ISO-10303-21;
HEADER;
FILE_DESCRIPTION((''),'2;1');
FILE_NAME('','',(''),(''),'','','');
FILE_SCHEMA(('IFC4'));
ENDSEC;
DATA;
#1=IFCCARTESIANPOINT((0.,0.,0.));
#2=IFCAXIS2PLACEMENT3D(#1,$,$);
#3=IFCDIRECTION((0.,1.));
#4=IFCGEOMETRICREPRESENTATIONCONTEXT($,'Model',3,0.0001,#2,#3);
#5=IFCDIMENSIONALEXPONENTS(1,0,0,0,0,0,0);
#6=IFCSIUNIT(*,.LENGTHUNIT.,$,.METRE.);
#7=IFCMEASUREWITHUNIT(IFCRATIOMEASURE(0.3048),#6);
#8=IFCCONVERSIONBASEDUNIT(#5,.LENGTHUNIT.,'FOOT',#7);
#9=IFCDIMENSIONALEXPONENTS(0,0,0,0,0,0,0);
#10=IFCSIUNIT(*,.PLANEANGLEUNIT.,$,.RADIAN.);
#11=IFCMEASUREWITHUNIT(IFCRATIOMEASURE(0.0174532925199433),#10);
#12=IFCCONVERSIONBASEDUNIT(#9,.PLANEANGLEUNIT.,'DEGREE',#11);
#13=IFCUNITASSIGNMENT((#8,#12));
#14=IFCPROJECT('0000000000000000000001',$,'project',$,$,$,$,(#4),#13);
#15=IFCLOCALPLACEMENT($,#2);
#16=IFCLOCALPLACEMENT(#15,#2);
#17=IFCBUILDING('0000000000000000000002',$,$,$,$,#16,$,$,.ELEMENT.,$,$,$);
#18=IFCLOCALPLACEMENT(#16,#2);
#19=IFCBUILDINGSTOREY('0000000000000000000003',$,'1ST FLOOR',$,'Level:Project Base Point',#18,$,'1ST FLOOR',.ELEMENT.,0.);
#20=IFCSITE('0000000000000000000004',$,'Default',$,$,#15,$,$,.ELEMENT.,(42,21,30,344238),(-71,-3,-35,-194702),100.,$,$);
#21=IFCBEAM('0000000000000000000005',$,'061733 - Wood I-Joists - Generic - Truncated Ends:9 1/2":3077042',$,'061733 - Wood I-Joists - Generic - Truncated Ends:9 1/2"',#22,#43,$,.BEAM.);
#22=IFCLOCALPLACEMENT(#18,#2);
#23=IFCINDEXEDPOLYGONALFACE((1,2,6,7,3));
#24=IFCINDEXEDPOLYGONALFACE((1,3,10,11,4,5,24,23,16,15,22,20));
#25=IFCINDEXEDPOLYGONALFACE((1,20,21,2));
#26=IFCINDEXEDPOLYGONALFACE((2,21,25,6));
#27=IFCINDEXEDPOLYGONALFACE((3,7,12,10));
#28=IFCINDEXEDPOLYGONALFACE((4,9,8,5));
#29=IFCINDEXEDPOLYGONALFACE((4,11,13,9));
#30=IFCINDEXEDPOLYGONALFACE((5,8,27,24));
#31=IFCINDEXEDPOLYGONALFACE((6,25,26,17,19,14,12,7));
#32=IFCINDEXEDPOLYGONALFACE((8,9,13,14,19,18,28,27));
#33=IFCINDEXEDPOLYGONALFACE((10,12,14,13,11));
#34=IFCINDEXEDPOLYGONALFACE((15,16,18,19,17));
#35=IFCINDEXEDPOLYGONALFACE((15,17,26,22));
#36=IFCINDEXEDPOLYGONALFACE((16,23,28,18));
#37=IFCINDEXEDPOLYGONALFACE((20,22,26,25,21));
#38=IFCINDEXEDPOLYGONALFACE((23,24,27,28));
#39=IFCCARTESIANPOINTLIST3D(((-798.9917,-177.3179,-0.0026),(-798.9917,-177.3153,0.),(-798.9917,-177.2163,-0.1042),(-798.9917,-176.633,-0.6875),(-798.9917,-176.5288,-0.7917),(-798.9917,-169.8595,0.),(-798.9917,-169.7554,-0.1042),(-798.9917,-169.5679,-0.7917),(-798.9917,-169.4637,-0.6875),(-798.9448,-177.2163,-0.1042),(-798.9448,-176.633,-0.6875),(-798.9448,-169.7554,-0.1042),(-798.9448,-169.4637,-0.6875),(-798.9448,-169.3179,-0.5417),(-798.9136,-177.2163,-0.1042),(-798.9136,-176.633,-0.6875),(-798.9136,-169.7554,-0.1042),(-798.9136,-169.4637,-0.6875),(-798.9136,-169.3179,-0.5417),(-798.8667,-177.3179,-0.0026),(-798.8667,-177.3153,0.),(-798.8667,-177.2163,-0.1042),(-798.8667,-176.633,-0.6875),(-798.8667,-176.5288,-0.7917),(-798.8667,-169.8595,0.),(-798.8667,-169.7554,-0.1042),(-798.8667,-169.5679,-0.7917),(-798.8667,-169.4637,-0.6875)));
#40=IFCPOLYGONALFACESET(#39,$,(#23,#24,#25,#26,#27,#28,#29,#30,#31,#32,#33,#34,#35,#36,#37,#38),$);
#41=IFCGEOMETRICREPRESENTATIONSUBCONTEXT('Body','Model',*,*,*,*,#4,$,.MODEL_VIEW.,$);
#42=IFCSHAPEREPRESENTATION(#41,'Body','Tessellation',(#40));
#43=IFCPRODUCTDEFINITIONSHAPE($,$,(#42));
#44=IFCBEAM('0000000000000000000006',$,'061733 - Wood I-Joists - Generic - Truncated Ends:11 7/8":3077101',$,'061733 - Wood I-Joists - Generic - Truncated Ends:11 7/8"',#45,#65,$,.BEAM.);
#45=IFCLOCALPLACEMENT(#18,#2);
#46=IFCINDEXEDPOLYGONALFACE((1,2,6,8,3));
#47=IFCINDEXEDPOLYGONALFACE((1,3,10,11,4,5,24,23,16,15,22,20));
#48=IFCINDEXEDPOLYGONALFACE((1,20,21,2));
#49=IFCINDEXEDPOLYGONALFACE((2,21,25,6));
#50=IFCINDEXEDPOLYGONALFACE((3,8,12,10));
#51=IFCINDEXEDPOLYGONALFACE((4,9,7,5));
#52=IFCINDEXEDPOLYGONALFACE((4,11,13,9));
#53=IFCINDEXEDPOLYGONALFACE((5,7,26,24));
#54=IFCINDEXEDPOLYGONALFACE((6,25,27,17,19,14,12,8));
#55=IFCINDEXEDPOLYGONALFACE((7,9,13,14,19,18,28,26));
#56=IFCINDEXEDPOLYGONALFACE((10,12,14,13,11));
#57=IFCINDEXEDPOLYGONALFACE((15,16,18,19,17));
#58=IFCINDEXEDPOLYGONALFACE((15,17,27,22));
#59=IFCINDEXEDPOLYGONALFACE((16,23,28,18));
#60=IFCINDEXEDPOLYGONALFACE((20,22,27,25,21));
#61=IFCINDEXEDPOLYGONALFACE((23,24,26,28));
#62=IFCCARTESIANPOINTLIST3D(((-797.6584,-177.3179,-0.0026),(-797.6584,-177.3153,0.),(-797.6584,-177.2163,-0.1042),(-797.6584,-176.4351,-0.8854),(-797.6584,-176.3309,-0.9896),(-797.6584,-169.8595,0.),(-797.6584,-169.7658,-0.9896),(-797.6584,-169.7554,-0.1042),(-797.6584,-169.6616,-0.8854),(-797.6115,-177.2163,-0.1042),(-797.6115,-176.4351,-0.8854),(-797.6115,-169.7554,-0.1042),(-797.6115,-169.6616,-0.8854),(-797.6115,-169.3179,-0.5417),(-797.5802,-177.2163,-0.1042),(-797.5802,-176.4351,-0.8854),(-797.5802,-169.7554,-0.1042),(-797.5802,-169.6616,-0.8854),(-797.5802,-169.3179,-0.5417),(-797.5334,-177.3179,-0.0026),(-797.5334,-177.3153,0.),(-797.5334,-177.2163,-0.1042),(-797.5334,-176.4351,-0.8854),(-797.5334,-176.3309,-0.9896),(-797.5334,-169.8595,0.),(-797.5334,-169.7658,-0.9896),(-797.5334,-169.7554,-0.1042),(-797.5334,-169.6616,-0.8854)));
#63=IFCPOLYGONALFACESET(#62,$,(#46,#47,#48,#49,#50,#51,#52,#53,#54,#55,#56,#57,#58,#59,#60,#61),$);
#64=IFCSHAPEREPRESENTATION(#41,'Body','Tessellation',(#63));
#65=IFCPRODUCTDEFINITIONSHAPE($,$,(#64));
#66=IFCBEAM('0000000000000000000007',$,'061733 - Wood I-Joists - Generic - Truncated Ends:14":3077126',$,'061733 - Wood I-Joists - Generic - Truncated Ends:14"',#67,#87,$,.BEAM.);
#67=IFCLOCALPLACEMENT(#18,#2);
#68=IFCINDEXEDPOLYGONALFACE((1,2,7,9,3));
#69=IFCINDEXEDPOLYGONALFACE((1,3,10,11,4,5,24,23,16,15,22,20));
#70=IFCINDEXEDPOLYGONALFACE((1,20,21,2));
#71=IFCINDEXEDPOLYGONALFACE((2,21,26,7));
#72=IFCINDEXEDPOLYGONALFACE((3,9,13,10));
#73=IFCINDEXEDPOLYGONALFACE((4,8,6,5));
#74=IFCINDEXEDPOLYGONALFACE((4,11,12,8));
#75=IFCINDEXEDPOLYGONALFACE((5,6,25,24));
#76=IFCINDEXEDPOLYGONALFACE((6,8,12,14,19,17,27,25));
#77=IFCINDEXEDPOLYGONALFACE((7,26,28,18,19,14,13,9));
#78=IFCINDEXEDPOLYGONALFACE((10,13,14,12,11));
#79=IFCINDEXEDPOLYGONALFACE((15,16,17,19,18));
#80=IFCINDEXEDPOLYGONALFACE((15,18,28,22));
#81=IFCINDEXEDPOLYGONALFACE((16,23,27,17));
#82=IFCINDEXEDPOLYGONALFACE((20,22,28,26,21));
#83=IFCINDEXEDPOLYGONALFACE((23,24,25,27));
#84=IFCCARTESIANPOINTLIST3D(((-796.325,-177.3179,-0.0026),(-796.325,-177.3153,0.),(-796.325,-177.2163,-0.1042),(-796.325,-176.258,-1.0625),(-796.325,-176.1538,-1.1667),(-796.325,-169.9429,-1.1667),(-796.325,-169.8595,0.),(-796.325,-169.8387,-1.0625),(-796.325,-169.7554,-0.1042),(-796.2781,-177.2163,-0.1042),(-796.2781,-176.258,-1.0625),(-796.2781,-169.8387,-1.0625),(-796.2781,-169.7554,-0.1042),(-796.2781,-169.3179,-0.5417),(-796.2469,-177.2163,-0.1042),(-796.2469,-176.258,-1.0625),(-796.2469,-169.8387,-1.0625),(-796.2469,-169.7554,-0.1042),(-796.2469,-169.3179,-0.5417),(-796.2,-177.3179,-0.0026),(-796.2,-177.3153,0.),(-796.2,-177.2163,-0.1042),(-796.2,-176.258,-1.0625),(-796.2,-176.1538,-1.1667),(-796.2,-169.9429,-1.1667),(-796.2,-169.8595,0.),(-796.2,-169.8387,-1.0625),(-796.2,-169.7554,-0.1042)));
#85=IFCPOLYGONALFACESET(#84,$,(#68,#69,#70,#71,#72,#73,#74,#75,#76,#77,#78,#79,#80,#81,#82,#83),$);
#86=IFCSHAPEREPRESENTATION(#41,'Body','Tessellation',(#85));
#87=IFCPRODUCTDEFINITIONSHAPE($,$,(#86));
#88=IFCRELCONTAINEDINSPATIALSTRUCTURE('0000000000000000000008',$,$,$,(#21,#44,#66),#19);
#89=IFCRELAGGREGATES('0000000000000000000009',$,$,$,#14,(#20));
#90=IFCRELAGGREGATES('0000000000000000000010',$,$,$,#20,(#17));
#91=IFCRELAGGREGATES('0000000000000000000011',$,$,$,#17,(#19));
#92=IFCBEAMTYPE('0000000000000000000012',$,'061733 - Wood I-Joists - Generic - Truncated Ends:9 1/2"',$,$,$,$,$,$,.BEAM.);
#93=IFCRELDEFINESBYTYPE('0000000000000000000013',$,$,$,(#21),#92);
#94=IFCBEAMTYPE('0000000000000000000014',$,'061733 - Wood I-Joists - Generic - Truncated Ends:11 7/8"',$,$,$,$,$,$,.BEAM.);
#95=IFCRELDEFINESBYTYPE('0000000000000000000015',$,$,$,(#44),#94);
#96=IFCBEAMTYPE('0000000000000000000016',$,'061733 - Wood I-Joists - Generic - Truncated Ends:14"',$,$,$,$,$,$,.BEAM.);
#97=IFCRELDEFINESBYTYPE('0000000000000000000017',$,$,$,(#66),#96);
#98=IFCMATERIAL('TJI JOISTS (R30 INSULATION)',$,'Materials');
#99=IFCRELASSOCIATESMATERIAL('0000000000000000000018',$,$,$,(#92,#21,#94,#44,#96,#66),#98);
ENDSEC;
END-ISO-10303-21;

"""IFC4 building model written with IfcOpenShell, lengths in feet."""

from ifc_helpers import new_model, entity, si_unit, converted_unit, direction, frame, origin, place, context, subcontext, project, spatial, polyline, outline, extrude, clip, bounded_halfspace, source, transform, mapped, material, material_profile, profile_set, profile_usage, type_object, type_shapes, element, save


model = new_model("IFC4")

# Units and contexts
model_context = context("Model", 3, precision=0.0001, world=origin(), true_north=direction((0.0, 1.0)))
body_context = subcontext(model_context, "Body", "Model", "MODEL_VIEW")
ifc_project = project(units=[converted_unit("LENGTHUNIT", "FOOT", entity("IfcRatioMeasure", 0.3048), si_unit("LENGTHUNIT", "METRE"), dimensions=[1, 0, 0, 0, 0, 0, 0]), converted_unit("PLANEANGLEUNIT", "DEGREE", entity("IfcRatioMeasure", 0.0174532925199433), si_unit("PLANEANGLEUNIT", "RADIAN"), dimensions=[0, 0, 0, 0, 0, 0, 0])], contexts=[model_context])

# Site, building, storey
site_placement = place(None, origin())
site = spatial("IfcSite", under=ifc_project, at=site_placement, Name="Default", CompositionType="ELEMENT", RefLatitude=(42, 21, 30, 344238), RefLongitude=(-71, -3, -35, -194702), RefElevation=100.0)
building_placement = place(site_placement, origin())
building = spatial("IfcBuilding", under=site, at=building_placement, CompositionType="ELEMENT")
storey_placement = place(building_placement, origin())
storey = spatial("IfcBuildingStorey", under=building, at=storey_placement, Name="1ST FLOOR", ObjectType="Level:Project Base Point", LongName="1ST FLOOR", CompositionType="ELEMENT", Elevation=0.0)

# Beams
ifc_material_1 = material(Name="TJI JOISTS (R30 INSULATION)", Category="Materials")
ifc_material_profile_1 = material_profile(ifc_material_1, outline(polyline([(-0.0625, -0.2917), (-0.0625, -0.3958), (0.0625, -0.3958), (0.0625, -0.2917), (0.0156, -0.2917), (0.0156, 0.2917), (0.0625, 0.2917), (0.0625, 0.3958), (-0.0625, 0.3958), (-0.0625, 0.2917), (-0.0156, 0.2917), (-0.0156, -0.2917), (-0.0625, -0.2917)])), Name="9 1/2\"")
ifc_profile_set_1 = profile_set([ifc_material_profile_1], Name="9 1/2\"")
ifc_profile_usage_1 = profile_usage(ifc_profile_set_1, cardinal=8)
beam_type_1 = type_object("IfcBeamType", Name="061733 - Wood I-Joists - Generic - Truncated Ends:9 1/2\"", PredefinedType="BEAM", material=ifc_profile_set_1)
shared_shape_1 = source(origin(), body_context, "Body", "Clipping", [
    clip(clip(clip(clip(extrude(outline(polyline([(-0.0625, -0.2917), (-0.0625, -0.3958), (0.0625, -0.3958), (0.0625, -0.2917), (0.0156, -0.2917), (0.0156, 0.2917), (0.0625, 0.2917), (0.0625, 0.3958), (-0.0625, 0.3958), (-0.0625, 0.2917), (-0.0156, 0.2917), (-0.0156, -0.2917), (-0.0625, -0.2917)])), frame((-4.0, -0.0057, 0.0), z_axis=(-1.0, 0.0, 0.0), x_axis=(0.0, 1.0, 0.0)), (0.0, 0.0, -1.0), 8.0), bounded_halfspace(frame((-3.75, -0.0682, -0.3958), z_axis=(-0.707107, 0.0, -0.707107), x_axis=(0.0, 1.0, 0.0)), False, frame((-4.0, -0.0057, 0.0), z_axis=(-1.0, 0.0, 0.0), x_axis=(0.0, 1.0, 0.0)), polyline([(-0.0156, 0.1458), (0.0156, 0.1458), (0.0156, 0.2917), (0.0625, 0.2917), (0.0625, 0.3958), (-0.0625, 0.3958), (-0.0625, 0.2917), (-0.0156, 0.2917), (-0.0156, 0.1458)]))), bounded_halfspace(frame((-4.0, -0.0682, -0.1458), z_axis=(-0.707107, 0.0, 0.707107), x_axis=(0.0, 1.0, 0.0)), False, frame((-4.0, -0.0057, 0.0), z_axis=(-1.0, 0.0, 0.0), x_axis=(0.0, 1.0, 0.0)), polyline([(0.0156, 0.1458), (-0.0156, 0.1458), (-0.0156, -0.2917), (-0.0625, -0.2917), (-0.0625, -0.3958), (0.0625, -0.3958), (0.0625, -0.2917), (0.0156, -0.2917), (0.0156, 0.1458)]))), bounded_halfspace(frame((4.0, -0.0682, 0.3932), z_axis=(0.707107, 0.0, -0.707107), x_axis=(0.0, 1.0, 0.0)), False, frame((-4.0, -0.0057, 0.0), z_axis=(-1.0, 0.0, 0.0), x_axis=(0.0, 1.0, 0.0)), polyline([(0.0625, -0.3932), (-0.0625, -0.3932), (-0.0625, -0.2917), (-0.0156, -0.2917), (-0.0156, 0.2917), (-0.0625, 0.2917), (-0.0625, 0.3958), (0.0625, 0.3958), (0.0625, 0.2917), (0.0156, 0.2917), (0.0156, -0.2917), (0.0625, -0.2917), (0.0625, -0.3932)]))), bounded_halfspace(frame((3.9974, -0.0682, 0.3958), z_axis=(0.707107, 0.0, 0.707107), x_axis=(0.0, 1.0, 0.0)), False, frame((-4.0, -0.0057, 0.0), z_axis=(-1.0, 0.0, 0.0), x_axis=(0.0, 1.0, 0.0)), polyline([(-0.0625, -0.3932), (0.0625, -0.3932), (0.0625, -0.3958), (-0.0625, -0.3958), (-0.0625, -0.3932)]))),
])
type_shapes(beam_type_1, [shared_shape_1])
beam_1_placement = place(storey_placement, frame((-798.9235, -173.3179, -0.3958), z_axis=(0.0, 0.0, 1.0), x_axis=(0.0, -1.0, 0.0)))
element("IfcBeam", 1, at=beam_1_placement, inside=storey, type_object=beam_type_1, material=ifc_profile_usage_1, Name="061733 - Wood I-Joists - Generic - Truncated Ends:9 1/2\":3077042", ObjectType="061733 - Wood I-Joists - Generic - Truncated Ends:9 1/2\"", PredefinedType="BEAM", context=body_context, shape_type="MappedRepresentation", body=[
    mapped(shared_shape_1, transform((0.0, 0.0, 0.0), scale=1.0)),
])
ifc_material_profile_2 = material_profile(ifc_material_1, outline(polyline([(-0.0625, -0.3906), (-0.0625, -0.4948), (0.0625, -0.4948), (0.0625, -0.3906), (0.0156, -0.3906), (0.0156, 0.3906), (0.0625, 0.3906), (0.0625, 0.4948), (-0.0625, 0.4948), (-0.0625, 0.3906), (-0.0156, 0.3906), (-0.0156, -0.3906), (-0.0625, -0.3906)])), Name="11 7/8\"")
ifc_profile_set_2 = profile_set([ifc_material_profile_2], Name="11 7/8\"")
ifc_profile_usage_2 = profile_usage(ifc_profile_set_2, cardinal=8)
beam_type_2 = type_object("IfcBeamType", Name="061733 - Wood I-Joists - Generic - Truncated Ends:11 7/8\"", PredefinedType="BEAM", material=ifc_profile_set_2)
shared_shape_2 = source(origin(), body_context, "Body", "Clipping", [
    clip(clip(clip(clip(extrude(outline(polyline([(-0.0625, -0.3906), (-0.0625, -0.4948), (0.0625, -0.4948), (0.0625, -0.3906), (0.0156, -0.3906), (0.0156, 0.3906), (0.0625, 0.3906), (0.0625, 0.4948), (-0.0625, 0.4948), (-0.0625, 0.3906), (-0.0156, 0.3906), (-0.0156, -0.3906), (-0.0625, -0.3906)])), frame((-4.0, -0.0057, 0.0), z_axis=(-1.0, 0.0, 0.0), x_axis=(0.0, 1.0, 0.0)), (0.0, 0.0, -1.0), 8.0), bounded_halfspace(frame((-3.5521, -0.0682, -0.4948), z_axis=(-0.707107, 0.0, -0.707107), x_axis=(0.0, 1.0, 0.0)), False, frame((-4.0, -0.0057, 0.0), z_axis=(-1.0, 0.0, 0.0), x_axis=(0.0, 1.0, 0.0)), polyline([(-0.0156, 0.0469), (0.0156, 0.0469), (0.0156, 0.3906), (0.0625, 0.3906), (0.0625, 0.4948), (-0.0625, 0.4948), (-0.0625, 0.3906), (-0.0156, 0.3906), (-0.0156, 0.0469)]))), bounded_halfspace(frame((-4.0, -0.0682, -0.0469), z_axis=(-0.707107, 0.0, 0.707107), x_axis=(0.0, 1.0, 0.0)), False, frame((-4.0, -0.0057, 0.0), z_axis=(-1.0, 0.0, 0.0), x_axis=(0.0, 1.0, 0.0)), polyline([(0.0156, 0.0469), (-0.0156, 0.0469), (-0.0156, -0.3906), (-0.0625, -0.3906), (-0.0625, -0.4948), (0.0625, -0.4948), (0.0625, -0.3906), (0.0156, -0.3906), (0.0156, 0.0469)]))), bounded_halfspace(frame((4.0, -0.0682, 0.4922), z_axis=(0.707107, 0.0, -0.707107), x_axis=(0.0, 1.0, 0.0)), False, frame((-4.0, -0.0057, 0.0), z_axis=(-1.0, 0.0, 0.0), x_axis=(0.0, 1.0, 0.0)), polyline([(0.0625, -0.4922), (-0.0625, -0.4922), (-0.0625, -0.3906), (-0.0156, -0.3906), (-0.0156, 0.3906), (-0.0625, 0.3906), (-0.0625, 0.4948), (0.0625, 0.4948), (0.0625, 0.3906), (0.0156, 0.3906), (0.0156, -0.3906), (0.0625, -0.3906), (0.0625, -0.4922)]))), bounded_halfspace(frame((3.9974, -0.0682, 0.4948), z_axis=(0.707107, 0.0, 0.707107), x_axis=(0.0, 1.0, 0.0)), False, frame((-4.0, -0.0057, 0.0), z_axis=(-1.0, 0.0, 0.0), x_axis=(0.0, 1.0, 0.0)), polyline([(-0.0625, -0.4922), (0.0625, -0.4922), (0.0625, -0.4948), (-0.0625, -0.4948), (-0.0625, -0.4922)]))),
])
type_shapes(beam_type_2, [shared_shape_2])
beam_2_placement = place(storey_placement, frame((-797.5901, -173.3179, -0.4948), z_axis=(0.0, 0.0, 1.0), x_axis=(0.0, -1.0, 0.0)))
element("IfcBeam", 2, at=beam_2_placement, inside=storey, type_object=beam_type_2, material=ifc_profile_usage_2, Name="061733 - Wood I-Joists - Generic - Truncated Ends:11 7/8\":3077101", ObjectType="061733 - Wood I-Joists - Generic - Truncated Ends:11 7/8\"", PredefinedType="BEAM", context=body_context, shape_type="MappedRepresentation", body=[
    mapped(shared_shape_2, transform((0.0, 0.0, 0.0), scale=1.0)),
])
ifc_material_profile_3 = material_profile(ifc_material_1, outline(polyline([(-0.0625, -0.4792), (-0.0625, -0.5833), (0.0625, -0.5833), (0.0625, -0.4792), (0.0156, -0.4792), (0.0156, 0.4792), (0.0625, 0.4792), (0.0625, 0.5833), (-0.0625, 0.5833), (-0.0625, 0.4792), (-0.0156, 0.4792), (-0.0156, -0.4792), (-0.0625, -0.4792)])), Name="14\"")
ifc_profile_set_3 = profile_set([ifc_material_profile_3], Name="14\"")
ifc_profile_usage_3 = profile_usage(ifc_profile_set_3, cardinal=8)
beam_type_3 = type_object("IfcBeamType", Name="061733 - Wood I-Joists - Generic - Truncated Ends:14\"", PredefinedType="BEAM", material=ifc_profile_set_3)
shared_shape_3 = source(origin(), body_context, "Body", "Clipping", [
    clip(clip(clip(clip(extrude(outline(polyline([(-0.0625, -0.4792), (-0.0625, -0.5833), (0.0625, -0.5833), (0.0625, -0.4792), (0.0156, -0.4792), (0.0156, 0.4792), (0.0625, 0.4792), (0.0625, 0.5833), (-0.0625, 0.5833), (-0.0625, 0.4792), (-0.0156, 0.4792), (-0.0156, -0.4792), (-0.0625, -0.4792)])), frame((-4.0, -0.0057, 0.0), z_axis=(-1.0, 0.0, 0.0), x_axis=(0.0, 1.0, 0.0)), (0.0, 0.0, -1.0), 8.0), bounded_halfspace(frame((-3.375, -0.0682, -0.5833), z_axis=(-0.707107, 0.0, -0.707107), x_axis=(0.0, 1.0, 0.0)), False, frame((-4.0, -0.0057, 0.0), z_axis=(-1.0, 0.0, 0.0), x_axis=(0.0, 1.0, 0.0)), polyline([(-0.0156, -0.0417), (0.0156, -0.0417), (0.0156, 0.4792), (0.0625, 0.4792), (0.0625, 0.5833), (-0.0625, 0.5833), (-0.0625, 0.4792), (-0.0156, 0.4792), (-0.0156, -0.0417)]))), bounded_halfspace(frame((-4.0, -0.0682, 0.0417), z_axis=(-0.707107, 0.0, 0.707107), x_axis=(0.0, 1.0, 0.0)), False, frame((-4.0, -0.0057, 0.0), z_axis=(-1.0, 0.0, 0.0), x_axis=(0.0, 1.0, 0.0)), polyline([(0.0156, -0.0417), (-0.0156, -0.0417), (-0.0156, -0.4792), (-0.0625, -0.4792), (-0.0625, -0.5833), (0.0625, -0.5833), (0.0625, -0.4792), (0.0156, -0.4792), (0.0156, -0.0417)]))), bounded_halfspace(frame((4.0, -0.0682, 0.5807), z_axis=(0.707107, 0.0, -0.707107), x_axis=(0.0, 1.0, 0.0)), False, frame((-4.0, -0.0057, 0.0), z_axis=(-1.0, 0.0, 0.0), x_axis=(0.0, 1.0, 0.0)), polyline([(0.0625, -0.5807), (-0.0625, -0.5807), (-0.0625, -0.4792), (-0.0156, -0.4792), (-0.0156, 0.4792), (-0.0625, 0.4792), (-0.0625, 0.5833), (0.0625, 0.5833), (0.0625, 0.4792), (0.0156, 0.4792), (0.0156, -0.4792), (0.0625, -0.4792), (0.0625, -0.5807)]))), bounded_halfspace(frame((3.9974, -0.0682, 0.5833), z_axis=(0.707107, 0.0, 0.707107), x_axis=(0.0, 1.0, 0.0)), False, frame((-4.0, -0.0057, 0.0), z_axis=(-1.0, 0.0, 0.0), x_axis=(0.0, 1.0, 0.0)), polyline([(-0.0625, -0.5807), (0.0625, -0.5807), (0.0625, -0.5833), (-0.0625, -0.5833), (-0.0625, -0.5807)]))),
])
type_shapes(beam_type_3, [shared_shape_3])
beam_3_placement = place(storey_placement, frame((-796.2568, -173.3179, -0.5833), z_axis=(0.0, 0.0, 1.0), x_axis=(0.0, -1.0, 0.0)))
element("IfcBeam", 3, at=beam_3_placement, inside=storey, type_object=beam_type_3, material=ifc_profile_usage_3, Name="061733 - Wood I-Joists - Generic - Truncated Ends:14\":3077126", ObjectType="061733 - Wood I-Joists - Generic - Truncated Ends:14\"", PredefinedType="BEAM", context=body_context, shape_type="MappedRepresentation", body=[
    mapped(shared_shape_3, transform((0.0, 0.0, 0.0), scale=1.0)),
])

save(model, "model.ifc")
